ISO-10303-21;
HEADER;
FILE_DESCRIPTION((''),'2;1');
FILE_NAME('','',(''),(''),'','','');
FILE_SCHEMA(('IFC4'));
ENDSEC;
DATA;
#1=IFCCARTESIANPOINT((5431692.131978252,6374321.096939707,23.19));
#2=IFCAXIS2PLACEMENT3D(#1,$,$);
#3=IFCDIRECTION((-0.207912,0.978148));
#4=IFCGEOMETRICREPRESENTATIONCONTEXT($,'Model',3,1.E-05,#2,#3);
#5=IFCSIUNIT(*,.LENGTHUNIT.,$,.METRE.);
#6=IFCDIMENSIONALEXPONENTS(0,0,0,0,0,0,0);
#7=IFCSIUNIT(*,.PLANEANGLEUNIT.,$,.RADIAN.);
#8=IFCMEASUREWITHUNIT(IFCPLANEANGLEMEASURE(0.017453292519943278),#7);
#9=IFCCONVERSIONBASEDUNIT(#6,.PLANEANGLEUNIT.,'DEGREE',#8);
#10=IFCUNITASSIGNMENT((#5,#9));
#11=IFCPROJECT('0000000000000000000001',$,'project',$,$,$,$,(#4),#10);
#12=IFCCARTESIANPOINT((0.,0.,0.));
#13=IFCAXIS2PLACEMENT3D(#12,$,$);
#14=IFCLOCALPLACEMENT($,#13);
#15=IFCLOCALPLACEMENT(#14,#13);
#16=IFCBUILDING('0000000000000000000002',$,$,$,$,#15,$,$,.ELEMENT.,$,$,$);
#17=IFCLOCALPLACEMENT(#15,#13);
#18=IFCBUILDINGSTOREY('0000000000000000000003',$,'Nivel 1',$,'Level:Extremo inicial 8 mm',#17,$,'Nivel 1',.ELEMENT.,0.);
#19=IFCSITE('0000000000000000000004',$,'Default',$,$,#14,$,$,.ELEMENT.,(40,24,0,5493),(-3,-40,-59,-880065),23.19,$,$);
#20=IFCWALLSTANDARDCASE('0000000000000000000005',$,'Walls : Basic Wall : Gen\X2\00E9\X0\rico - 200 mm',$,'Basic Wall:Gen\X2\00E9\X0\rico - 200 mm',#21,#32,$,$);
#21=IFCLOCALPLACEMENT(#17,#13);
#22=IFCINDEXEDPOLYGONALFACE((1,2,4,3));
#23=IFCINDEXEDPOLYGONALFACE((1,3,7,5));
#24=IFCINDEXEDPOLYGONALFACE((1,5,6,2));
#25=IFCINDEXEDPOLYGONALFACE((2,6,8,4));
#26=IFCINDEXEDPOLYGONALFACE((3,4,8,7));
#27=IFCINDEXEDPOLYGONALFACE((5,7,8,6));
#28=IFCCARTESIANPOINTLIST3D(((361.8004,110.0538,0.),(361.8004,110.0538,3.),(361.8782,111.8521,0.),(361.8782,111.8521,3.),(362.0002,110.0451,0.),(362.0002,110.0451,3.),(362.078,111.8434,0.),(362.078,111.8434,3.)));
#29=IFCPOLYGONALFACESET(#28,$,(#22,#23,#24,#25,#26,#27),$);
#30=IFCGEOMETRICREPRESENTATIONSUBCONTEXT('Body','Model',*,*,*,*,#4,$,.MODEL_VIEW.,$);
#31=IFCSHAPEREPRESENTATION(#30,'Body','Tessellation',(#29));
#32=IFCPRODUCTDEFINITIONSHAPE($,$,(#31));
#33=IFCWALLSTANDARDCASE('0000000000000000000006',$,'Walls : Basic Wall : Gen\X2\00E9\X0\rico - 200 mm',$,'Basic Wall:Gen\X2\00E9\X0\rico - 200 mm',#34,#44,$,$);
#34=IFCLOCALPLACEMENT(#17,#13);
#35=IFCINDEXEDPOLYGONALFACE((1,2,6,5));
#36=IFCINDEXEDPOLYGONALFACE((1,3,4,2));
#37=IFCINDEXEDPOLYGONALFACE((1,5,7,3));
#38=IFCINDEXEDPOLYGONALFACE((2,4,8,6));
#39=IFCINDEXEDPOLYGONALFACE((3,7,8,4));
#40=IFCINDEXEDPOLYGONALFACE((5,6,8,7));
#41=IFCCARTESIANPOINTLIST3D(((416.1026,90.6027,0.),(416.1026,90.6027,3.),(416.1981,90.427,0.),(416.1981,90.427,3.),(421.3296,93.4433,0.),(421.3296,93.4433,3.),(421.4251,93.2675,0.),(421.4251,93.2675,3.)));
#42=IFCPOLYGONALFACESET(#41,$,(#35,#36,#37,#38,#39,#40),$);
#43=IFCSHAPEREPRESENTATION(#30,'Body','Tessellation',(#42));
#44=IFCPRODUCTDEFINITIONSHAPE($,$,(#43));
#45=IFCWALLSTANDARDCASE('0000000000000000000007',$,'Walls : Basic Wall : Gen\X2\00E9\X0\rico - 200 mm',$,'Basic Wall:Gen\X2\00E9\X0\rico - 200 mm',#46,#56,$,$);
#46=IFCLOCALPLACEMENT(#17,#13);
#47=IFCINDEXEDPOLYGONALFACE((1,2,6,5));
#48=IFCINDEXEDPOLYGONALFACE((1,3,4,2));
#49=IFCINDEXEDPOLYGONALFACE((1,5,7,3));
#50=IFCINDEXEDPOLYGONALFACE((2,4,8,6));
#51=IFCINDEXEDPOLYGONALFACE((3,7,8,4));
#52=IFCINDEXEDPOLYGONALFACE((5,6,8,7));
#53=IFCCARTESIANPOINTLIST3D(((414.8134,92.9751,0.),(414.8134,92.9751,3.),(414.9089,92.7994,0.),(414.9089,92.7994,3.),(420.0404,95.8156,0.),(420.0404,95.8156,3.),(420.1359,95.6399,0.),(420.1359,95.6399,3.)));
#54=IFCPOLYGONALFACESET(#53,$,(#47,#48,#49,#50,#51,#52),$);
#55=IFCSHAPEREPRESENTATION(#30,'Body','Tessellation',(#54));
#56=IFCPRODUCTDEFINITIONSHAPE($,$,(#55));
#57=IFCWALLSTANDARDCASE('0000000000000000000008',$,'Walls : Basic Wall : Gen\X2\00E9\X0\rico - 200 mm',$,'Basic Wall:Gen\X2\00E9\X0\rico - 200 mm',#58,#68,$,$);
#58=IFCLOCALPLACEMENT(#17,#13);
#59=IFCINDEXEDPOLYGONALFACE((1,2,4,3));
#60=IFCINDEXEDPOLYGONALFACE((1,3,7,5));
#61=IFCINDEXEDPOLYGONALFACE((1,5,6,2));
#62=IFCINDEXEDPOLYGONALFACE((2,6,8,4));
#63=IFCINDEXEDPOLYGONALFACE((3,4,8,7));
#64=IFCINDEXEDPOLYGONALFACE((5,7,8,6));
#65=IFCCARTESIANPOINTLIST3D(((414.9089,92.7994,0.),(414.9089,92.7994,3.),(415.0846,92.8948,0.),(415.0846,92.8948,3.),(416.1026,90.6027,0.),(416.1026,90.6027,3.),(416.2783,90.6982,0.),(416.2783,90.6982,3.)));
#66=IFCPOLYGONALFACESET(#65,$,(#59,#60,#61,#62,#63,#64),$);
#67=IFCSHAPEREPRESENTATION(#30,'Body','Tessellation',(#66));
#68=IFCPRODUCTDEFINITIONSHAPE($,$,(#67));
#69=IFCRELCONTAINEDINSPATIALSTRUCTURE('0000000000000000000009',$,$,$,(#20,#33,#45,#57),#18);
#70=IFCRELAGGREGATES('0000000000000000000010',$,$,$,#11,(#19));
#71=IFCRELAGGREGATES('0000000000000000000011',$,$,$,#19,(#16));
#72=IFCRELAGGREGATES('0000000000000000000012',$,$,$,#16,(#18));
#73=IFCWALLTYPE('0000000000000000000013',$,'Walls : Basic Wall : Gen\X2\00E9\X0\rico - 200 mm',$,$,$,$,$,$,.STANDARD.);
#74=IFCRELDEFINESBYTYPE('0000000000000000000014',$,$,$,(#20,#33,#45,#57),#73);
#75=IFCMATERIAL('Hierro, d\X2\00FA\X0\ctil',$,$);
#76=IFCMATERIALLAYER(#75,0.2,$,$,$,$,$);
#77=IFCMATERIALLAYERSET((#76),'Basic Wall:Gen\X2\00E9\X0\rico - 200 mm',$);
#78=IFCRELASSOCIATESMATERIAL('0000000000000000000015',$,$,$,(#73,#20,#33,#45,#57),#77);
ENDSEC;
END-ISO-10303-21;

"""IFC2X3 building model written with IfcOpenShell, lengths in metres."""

from ifc_helpers import new_model, entity, si_unit, converted_unit, direction, frame, frame_2d, origin, place, context, subcontext, project, spatial, polyline, rectangle, extrude, clip, bounded_halfspace, material, layer, layer_set, layer_usage, type_object, element, save


model = new_model("IFC2X3")

# Units and contexts
model_context = context("Model", 3, precision=1e-05, world=frame((5431692.131978252, 6374321.096939707, 23.19)), true_north=direction((-0.207912, 0.978148)))
body_context = subcontext(model_context, "Body", "Model", "MODEL_VIEW")
ifc_project = project(units=[si_unit("LENGTHUNIT", "METRE"), converted_unit("PLANEANGLEUNIT", "DEGREE", entity("IfcPlaneAngleMeasure", 0.017453292519943278), si_unit("PLANEANGLEUNIT", "RADIAN"), dimensions=[0, 0, 0, 0, 0, 0, 0])], contexts=[model_context])

# Site, building, storey
site_placement = place(None, origin())
site = spatial("IfcSite", under=ifc_project, at=site_placement, Name="Default", CompositionType="ELEMENT", RefLatitude=(40, 24, 0, 5493), RefLongitude=(-3, -40, -59, -880065), RefElevation=23.19)
building_placement = place(site_placement, origin())
building = spatial("IfcBuilding", under=site, at=building_placement, CompositionType="ELEMENT")
storey_placement = place(building_placement, origin())
storey = spatial("IfcBuildingStorey", under=building, at=storey_placement, Name="Nivel 1", ObjectType="Level:Extremo inicial 8 mm", LongName="Nivel 1", CompositionType="ELEMENT", Elevation=0.0)

# Walls
ifc_material = material(Name="Hierro, dúctil")
ifc_layer = layer(ifc_material, 0.2)
ifc_layer_set = layer_set([ifc_layer], Name="Basic Wall:Genérico - 200 mm")
wall_type = type_object("IfcWallType", Name="Walls : Basic Wall : Genérico - 200 mm", PredefinedType="STANDARD", material=ifc_layer_set)
ifc_layer_usage_1 = layer_usage(ifc_layer_set, "AXIS2", "NEGATIVE", 0.1)
wall_1_placement = place(storey_placement, frame((361.9781, 111.8477, 0.0), z_axis=(0.0, 0.0, 1.0), x_axis=(-0.043255, -0.999064, 0.0)))
element("IfcWallStandardCase", 1, at=wall_1_placement, inside=storey, type_object=wall_type, material=ifc_layer_usage_1, Name="Walls : Basic Wall : Genérico - 200 mm", ObjectType="Basic Wall:Genérico - 200 mm", context=body_context, shape_type="SweptSolid", body=[
    extrude(rectangle(XDim=1.8, YDim=0.2, at=frame_2d((0.9, 0.0), x_axis=(-1.0, 0.0))), origin(), (0.0, 0.0, 1.0), 3.0),
])
ifc_layer_usage_2 = layer_usage(ifc_layer_set, "AXIS2", "NEGATIVE", 0.1)
wall_2_placement = place(storey_placement, frame((421.3773, 93.3554, 0.0), z_axis=(0.0, 0.0, 1.0), x_axis=(-0.878643, -0.47748, 0.0)))
element("IfcWallStandardCase", 2, at=wall_2_placement, inside=storey, type_object=wall_type, material=ifc_layer_usage_2, Name="Walls : Basic Wall : Genérico - 200 mm", ObjectType="Basic Wall:Genérico - 200 mm", context=body_context, shape_type="SweptSolid", body=[
    extrude(rectangle(XDim=5.949, YDim=0.2, at=frame_2d((2.9745, 0.0), x_axis=(-1.0, 0.0))), origin(), (0.0, 0.0, 1.0), 3.0),
])
ifc_layer_usage_3 = layer_usage(ifc_layer_set, "AXIS2", "NEGATIVE", 0.1)
wall_3_placement = place(storey_placement, frame((420.0881, 95.7277, 0.0), z_axis=(0.0, 0.0, 1.0), x_axis=(-0.878643, -0.47748, 0.0)))
element("IfcWallStandardCase", 3, at=wall_3_placement, inside=storey, type_object=wall_type, material=ifc_layer_usage_3, Name="Walls : Basic Wall : Genérico - 200 mm", ObjectType="Basic Wall:Genérico - 200 mm", context=body_context, shape_type="SweptSolid", body=[
    extrude(rectangle(XDim=5.949, YDim=0.2, at=frame_2d((2.9745, 0.0), x_axis=(-1.0, 0.0))), origin(), (0.0, 0.0, 1.0), 3.0),
])
ifc_layer_usage_4 = layer_usage(ifc_layer_set, "AXIS2", "NEGATIVE", 0.1)
wall_4_placement = place(storey_placement, frame((414.9967, 92.8471, 0.0), z_axis=(0.0, 0.0, 1.0), x_axis=(0.47748, -0.878643, 0.0)))
element("IfcWallStandardCase", 4, at=wall_4_placement, inside=storey, type_object=wall_type, material=ifc_layer_usage_4, Name="Walls : Basic Wall : Genérico - 200 mm", ObjectType="Basic Wall:Genérico - 200 mm", context=body_context, shape_type="Clipping", body=[
    clip(extrude(rectangle(XDim=2.5, YDim=0.2, at=frame_2d((1.25, 0.0), x_axis=(-1.0, 0.0))), origin(), (0.0, 0.0, 1.0), 3.0), bounded_halfspace(frame((0.0, -0.1, 3.0), z_axis=(0.0, 0.0, 1.0), x_axis=(0.47748, 0.878643, 0.0)), False, frame((0.0, -0.1, 3.0)), polyline([(0.0, 0.0), (2.5, 0.0), (2.5, 0.2), (0.0, 0.2), (0.0, 0.0)]))),
])

save(model, "model.ifc")
